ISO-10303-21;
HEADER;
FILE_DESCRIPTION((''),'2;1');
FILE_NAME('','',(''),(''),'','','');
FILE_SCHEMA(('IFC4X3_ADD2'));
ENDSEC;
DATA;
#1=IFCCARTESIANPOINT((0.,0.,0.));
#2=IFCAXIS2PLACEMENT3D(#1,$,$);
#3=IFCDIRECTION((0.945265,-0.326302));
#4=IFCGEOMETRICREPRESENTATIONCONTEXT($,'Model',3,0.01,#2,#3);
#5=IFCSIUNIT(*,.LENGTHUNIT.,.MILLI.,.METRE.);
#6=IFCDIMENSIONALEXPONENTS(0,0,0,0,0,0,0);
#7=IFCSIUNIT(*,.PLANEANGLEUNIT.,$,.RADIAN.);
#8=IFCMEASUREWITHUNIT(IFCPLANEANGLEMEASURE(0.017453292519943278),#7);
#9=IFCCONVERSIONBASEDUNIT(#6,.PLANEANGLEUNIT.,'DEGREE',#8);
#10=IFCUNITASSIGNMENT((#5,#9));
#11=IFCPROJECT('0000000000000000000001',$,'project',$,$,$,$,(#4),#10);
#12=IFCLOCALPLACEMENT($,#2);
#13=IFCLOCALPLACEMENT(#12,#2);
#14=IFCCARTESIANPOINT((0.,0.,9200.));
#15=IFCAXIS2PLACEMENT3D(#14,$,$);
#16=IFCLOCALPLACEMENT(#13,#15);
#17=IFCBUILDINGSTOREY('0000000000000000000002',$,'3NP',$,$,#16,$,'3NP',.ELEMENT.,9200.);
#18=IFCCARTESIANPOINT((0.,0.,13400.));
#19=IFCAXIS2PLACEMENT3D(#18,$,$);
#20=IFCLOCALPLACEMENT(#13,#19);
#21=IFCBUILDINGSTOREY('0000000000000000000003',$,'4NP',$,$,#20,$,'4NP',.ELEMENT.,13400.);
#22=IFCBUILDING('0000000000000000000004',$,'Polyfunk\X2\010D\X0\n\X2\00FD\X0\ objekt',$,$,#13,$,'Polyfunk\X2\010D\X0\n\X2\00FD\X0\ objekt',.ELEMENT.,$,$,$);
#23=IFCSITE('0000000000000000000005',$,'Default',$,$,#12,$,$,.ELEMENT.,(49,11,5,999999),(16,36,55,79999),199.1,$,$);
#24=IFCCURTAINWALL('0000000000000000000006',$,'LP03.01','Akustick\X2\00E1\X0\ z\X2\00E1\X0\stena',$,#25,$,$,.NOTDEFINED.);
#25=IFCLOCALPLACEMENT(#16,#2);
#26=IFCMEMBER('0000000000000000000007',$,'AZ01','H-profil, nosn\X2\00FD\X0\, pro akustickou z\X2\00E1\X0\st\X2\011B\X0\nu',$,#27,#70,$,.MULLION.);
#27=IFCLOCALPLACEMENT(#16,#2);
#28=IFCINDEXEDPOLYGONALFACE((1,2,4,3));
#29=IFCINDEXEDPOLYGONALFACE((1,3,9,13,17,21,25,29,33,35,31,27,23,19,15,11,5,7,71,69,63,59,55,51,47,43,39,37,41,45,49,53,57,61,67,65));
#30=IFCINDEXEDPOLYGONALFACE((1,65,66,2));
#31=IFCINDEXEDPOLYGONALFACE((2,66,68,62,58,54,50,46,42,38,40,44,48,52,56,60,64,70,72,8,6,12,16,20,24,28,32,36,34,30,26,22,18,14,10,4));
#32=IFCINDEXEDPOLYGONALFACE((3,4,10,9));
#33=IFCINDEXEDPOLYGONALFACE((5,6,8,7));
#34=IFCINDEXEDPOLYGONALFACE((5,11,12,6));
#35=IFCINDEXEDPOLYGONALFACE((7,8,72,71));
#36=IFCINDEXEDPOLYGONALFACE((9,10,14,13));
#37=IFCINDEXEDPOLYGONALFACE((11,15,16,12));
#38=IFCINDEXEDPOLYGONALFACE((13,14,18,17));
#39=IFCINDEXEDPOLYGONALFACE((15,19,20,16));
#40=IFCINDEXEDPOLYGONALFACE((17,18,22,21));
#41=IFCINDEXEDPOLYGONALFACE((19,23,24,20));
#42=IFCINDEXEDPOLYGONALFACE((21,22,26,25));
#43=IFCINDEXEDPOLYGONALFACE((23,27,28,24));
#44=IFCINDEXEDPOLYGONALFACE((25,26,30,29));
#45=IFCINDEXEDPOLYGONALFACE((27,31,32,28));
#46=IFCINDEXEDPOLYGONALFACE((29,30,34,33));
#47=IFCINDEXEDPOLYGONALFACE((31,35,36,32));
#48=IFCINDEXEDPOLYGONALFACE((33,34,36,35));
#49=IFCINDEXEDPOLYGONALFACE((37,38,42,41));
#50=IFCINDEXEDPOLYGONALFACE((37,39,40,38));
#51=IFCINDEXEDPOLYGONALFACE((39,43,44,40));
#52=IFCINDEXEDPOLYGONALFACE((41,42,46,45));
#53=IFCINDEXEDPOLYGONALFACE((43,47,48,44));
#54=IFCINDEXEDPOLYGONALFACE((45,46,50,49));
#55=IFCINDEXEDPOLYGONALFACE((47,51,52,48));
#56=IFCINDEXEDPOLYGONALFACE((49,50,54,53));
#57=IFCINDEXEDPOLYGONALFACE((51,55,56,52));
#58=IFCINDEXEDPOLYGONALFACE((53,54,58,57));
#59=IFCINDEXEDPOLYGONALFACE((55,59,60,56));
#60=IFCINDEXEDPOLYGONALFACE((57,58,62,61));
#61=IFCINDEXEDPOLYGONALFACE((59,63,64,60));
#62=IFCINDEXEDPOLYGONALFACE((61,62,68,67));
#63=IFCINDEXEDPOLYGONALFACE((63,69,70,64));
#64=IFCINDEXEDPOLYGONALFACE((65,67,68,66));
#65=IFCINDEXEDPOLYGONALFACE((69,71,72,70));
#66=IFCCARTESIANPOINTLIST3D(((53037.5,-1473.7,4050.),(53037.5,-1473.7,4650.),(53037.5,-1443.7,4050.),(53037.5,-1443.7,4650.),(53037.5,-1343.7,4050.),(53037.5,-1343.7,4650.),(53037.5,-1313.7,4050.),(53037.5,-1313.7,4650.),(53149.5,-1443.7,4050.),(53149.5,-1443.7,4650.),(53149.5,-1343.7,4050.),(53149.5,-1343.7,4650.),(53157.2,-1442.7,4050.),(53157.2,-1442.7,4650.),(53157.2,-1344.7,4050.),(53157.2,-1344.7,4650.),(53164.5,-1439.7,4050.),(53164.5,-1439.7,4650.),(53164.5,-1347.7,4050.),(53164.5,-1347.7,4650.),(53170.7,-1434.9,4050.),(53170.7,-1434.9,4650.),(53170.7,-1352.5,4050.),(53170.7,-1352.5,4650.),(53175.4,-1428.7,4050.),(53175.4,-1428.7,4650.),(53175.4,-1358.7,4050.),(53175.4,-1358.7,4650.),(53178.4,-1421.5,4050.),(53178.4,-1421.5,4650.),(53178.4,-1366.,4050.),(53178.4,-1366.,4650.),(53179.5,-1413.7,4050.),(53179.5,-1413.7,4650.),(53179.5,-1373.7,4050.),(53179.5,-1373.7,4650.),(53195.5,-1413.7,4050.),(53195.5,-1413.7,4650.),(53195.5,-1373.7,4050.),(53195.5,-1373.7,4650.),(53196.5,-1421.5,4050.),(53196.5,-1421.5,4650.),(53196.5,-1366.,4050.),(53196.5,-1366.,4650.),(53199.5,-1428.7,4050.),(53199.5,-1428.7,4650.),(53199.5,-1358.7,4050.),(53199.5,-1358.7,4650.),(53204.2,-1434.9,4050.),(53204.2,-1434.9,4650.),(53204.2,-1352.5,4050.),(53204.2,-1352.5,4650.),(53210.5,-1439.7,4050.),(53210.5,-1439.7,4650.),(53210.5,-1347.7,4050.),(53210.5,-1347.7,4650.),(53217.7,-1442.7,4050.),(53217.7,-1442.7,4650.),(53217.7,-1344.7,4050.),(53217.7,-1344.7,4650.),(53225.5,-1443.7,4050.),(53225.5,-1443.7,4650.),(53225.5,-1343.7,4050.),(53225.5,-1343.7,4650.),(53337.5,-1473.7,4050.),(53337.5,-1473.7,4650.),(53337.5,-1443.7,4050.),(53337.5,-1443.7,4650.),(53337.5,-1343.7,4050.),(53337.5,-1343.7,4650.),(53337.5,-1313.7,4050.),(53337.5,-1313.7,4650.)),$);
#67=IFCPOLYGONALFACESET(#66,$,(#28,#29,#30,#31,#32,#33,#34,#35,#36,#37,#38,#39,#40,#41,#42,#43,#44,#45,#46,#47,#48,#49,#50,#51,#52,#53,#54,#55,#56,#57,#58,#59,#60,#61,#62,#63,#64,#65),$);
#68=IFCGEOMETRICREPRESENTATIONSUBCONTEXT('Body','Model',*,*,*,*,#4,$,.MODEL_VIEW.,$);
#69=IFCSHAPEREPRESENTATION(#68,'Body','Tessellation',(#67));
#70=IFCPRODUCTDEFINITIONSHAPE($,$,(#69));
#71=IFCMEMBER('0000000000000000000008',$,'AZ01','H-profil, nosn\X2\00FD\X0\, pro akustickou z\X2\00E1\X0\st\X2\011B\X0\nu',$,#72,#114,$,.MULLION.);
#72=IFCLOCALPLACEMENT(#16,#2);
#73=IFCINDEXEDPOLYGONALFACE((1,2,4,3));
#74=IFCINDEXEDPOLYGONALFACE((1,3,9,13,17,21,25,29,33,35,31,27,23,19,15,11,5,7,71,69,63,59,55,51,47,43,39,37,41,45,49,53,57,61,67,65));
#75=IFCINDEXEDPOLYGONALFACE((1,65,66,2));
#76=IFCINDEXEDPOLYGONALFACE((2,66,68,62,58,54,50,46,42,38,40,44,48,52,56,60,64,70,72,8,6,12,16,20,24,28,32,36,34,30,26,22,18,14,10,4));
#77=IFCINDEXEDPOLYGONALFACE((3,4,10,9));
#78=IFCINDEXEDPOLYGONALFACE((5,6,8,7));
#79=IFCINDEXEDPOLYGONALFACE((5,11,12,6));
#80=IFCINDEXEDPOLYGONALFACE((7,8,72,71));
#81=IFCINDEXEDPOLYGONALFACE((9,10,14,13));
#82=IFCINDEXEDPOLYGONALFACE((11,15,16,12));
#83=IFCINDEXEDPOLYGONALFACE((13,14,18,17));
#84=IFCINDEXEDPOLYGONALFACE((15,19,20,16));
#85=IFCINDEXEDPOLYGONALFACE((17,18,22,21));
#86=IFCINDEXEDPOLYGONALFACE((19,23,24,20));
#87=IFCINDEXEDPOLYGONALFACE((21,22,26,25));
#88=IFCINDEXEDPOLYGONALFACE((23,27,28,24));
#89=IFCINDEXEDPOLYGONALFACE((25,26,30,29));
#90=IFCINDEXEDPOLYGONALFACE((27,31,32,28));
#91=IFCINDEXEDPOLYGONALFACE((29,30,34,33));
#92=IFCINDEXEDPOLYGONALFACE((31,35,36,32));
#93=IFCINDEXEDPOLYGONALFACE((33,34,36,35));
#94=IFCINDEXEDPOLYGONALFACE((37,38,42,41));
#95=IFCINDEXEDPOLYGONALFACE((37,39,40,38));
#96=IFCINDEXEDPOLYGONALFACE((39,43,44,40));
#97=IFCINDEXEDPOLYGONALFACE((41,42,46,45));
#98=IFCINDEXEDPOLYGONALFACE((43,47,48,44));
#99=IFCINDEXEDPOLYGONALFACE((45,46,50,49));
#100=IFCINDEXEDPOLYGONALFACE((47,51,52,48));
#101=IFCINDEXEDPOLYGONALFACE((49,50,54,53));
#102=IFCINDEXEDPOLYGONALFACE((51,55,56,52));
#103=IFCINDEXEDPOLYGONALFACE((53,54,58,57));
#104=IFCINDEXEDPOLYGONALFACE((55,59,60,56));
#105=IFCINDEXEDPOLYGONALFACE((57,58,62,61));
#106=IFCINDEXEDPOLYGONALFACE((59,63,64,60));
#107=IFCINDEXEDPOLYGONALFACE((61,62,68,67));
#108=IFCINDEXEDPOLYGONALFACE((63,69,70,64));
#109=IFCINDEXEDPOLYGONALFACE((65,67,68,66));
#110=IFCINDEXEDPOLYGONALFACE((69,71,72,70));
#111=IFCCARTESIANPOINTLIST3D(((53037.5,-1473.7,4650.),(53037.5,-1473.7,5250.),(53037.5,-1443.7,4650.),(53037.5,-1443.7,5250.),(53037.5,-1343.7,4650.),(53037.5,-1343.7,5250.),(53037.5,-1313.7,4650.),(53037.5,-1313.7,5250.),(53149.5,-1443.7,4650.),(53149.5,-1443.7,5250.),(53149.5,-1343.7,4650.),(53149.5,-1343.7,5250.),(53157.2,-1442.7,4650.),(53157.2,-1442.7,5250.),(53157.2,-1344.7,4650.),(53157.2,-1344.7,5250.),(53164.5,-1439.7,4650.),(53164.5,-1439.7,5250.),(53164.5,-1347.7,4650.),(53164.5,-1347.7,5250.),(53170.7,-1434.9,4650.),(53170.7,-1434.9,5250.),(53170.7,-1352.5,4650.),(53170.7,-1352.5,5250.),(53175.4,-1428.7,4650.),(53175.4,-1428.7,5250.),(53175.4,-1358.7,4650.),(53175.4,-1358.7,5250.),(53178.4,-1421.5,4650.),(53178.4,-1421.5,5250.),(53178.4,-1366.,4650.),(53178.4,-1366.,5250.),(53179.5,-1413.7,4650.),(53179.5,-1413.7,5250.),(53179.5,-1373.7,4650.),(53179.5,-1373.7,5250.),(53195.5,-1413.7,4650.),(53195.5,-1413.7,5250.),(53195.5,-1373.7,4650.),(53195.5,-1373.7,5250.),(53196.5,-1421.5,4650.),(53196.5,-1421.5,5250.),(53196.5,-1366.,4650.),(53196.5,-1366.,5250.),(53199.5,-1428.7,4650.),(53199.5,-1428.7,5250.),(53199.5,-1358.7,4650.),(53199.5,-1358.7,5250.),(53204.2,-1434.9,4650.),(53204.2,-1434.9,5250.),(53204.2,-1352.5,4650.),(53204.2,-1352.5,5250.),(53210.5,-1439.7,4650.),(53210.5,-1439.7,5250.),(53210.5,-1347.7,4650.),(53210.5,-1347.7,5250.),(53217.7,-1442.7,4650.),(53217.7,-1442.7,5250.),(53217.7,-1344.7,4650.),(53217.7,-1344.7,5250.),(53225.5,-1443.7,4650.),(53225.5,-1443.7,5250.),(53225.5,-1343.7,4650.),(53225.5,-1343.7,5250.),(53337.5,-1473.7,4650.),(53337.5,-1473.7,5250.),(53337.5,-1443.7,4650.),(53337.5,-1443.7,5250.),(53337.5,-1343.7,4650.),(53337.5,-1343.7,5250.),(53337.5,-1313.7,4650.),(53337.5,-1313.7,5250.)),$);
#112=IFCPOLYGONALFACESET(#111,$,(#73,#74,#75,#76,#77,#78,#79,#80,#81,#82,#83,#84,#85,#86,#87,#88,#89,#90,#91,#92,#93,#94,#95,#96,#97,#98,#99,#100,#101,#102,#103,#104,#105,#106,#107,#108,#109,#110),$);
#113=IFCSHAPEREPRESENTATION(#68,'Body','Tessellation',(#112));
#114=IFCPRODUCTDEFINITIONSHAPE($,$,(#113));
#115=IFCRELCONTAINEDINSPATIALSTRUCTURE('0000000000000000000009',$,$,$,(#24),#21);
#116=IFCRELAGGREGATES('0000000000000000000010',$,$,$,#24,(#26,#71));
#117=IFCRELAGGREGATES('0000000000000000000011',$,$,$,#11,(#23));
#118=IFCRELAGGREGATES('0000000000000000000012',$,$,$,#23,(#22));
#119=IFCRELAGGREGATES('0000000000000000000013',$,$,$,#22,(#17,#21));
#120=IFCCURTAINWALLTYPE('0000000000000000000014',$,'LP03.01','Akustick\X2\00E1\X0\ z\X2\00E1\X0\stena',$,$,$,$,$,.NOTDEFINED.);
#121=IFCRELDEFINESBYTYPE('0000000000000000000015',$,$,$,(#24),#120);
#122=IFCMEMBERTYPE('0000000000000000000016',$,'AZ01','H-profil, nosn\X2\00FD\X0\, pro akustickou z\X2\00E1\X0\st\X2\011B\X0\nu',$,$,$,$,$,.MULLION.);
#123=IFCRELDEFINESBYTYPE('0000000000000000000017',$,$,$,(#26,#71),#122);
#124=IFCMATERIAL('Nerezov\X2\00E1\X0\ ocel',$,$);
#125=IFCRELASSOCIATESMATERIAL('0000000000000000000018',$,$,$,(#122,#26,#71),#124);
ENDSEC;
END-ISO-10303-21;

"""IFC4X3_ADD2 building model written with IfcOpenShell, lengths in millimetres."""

from ifc_helpers import new_model, entity, si_unit, converted_unit, direction, frame, frame_2d, origin, place, context, subcontext, project, spatial, polyline, circle_curve, parameter, trimmed, segment, composite_curve, outline, extrude, source, transform, mapped, material, material_profile, profile_set, profile_usage, type_object, element, aggregate, save


model = new_model("IFC4X3_ADD2")

# Units and contexts
model_context = context("Model", 3, precision=0.01, world=origin(), true_north=direction((0.945265, -0.326302)))
body_context = subcontext(model_context, "Body", "Model", "MODEL_VIEW")
ifc_project = project(units=[si_unit("LENGTHUNIT", "METRE", prefix="MILLI"), converted_unit("PLANEANGLEUNIT", "DEGREE", entity("IfcPlaneAngleMeasure", 0.017453292519943278), si_unit("PLANEANGLEUNIT", "RADIAN"), dimensions=[0, 0, 0, 0, 0, 0, 0])], contexts=[model_context])

# Site, building, storey
site_placement = place(None, origin())
site = spatial("IfcSite", under=ifc_project, at=site_placement, Name="Default", CompositionType="ELEMENT", RefLatitude=(49, 11, 5, 999999), RefLongitude=(16, 36, 55, 79999), RefElevation=199.1)
building_placement = place(site_placement, origin())
building = spatial("IfcBuilding", under=site, at=building_placement, Name="Polyfunkčný objekt", LongName="Polyfunkčný objekt", CompositionType="ELEMENT")
storey_1_placement = place(building_placement, frame((0.0, 0.0, 9200.0)))
storey_1 = spatial("IfcBuildingStorey", under=building, at=storey_1_placement, Name="3NP", LongName="3NP", CompositionType="ELEMENT", Elevation=9200.0)

# Shared definitions
storey_2_placement = place(building_placement, frame((0.0, 0.0, 13400.0)))
storey_2 = spatial("IfcBuildingStorey", under=building, at=storey_2_placement, Name="4NP", LongName="4NP", CompositionType="ELEMENT", Elevation=13400.0)

# Curtain wall, members
curtain_wall_type_1 = type_object("IfcCurtainWallType", Name="LP03.01", Description="Akustická zástena", PredefinedType="NOTDEFINED")
curtain_wall_1_placement = place(storey_2_placement, frame((0.0, 0.0, -13400.0)))
curtain_wall_1 = element("IfcCurtainWall", 1, at=curtain_wall_1_placement, inside=storey_2, type_object=curtain_wall_type_1, Name="LP03.01", Description="Akustická zástena", PredefinedType="NOTDEFINED")
ifc_material_1 = material(Name="Nerezová ocel")
ifc_material_profile_1 = material_profile(ifc_material_1, outline(composite_curve([segment(polyline([(50.0, -150.0), (80.0, -150.0)]), True, "CONTINUOUS"), segment(polyline([(80.0, -150.0), (80.0, 150.0)]), True, "CONTINUOUS"), segment(polyline([(80.0, 150.0), (50.0, 150.0)]), True, "CONTINUOUS"), segment(polyline([(50.0, 150.0), (50.0, 38.0)]), True, "CONTINUOUS"), segment(trimmed(circle_curve(frame_2d((20.0, 38.0), x_axis=(0.0, 1.0)), 30.0), [parameter(180.0)], [parameter(270.0)], True, "PARAMETER"), False, "CONTINUOUS"), segment(polyline([(20.0, 8.0), (-20.0, 8.0)]), True, "CONTINUOUS"), segment(trimmed(circle_curve(frame_2d((-20.0, 38.0), x_axis=(0.0, 1.0)), 30.0), [parameter(90.0)], [parameter(180.0)], True, "PARAMETER"), False, "CONTINUOUS"), segment(polyline([(-50.0, 38.0), (-50.0, 150.0)]), True, "CONTINUOUS"), segment(polyline([(-50.0, 150.0), (-80.0, 150.0)]), True, "CONTINUOUS"), segment(polyline([(-80.0, 150.0), (-80.0, -150.0)]), True, "CONTINUOUS"), segment(polyline([(-80.0, -150.0), (-50.0, -150.0)]), True, "CONTINUOUS"), segment(polyline([(-50.0, -150.0), (-50.0, -38.0)]), True, "CONTINUOUS"), segment(trimmed(circle_curve(frame_2d((-20.0, -38.0), x_axis=(0.0, 1.0)), 30.0), [parameter(0.0)], [parameter(90.0)], True, "PARAMETER"), False, "CONTINUOUS"), segment(polyline([(-20.0, -8.0), (20.0, -8.0)]), True, "CONTINUOUS"), segment(trimmed(circle_curve(frame_2d((20.0, -38.0), x_axis=(0.0, 1.0)), 30.0), [parameter(270.0)], [parameter(0.0)], True, "PARAMETER"), False, "CONTINUOUS"), segment(polyline([(50.0, -38.0), (50.0, -150.0)]), True, "CONTINUOUS")], self_intersect=False)), Name="Profil zástena")
ifc_profile_set_1 = profile_set([ifc_material_profile_1], Name="Profil zástena")
ifc_profile_usage_1 = profile_usage(ifc_profile_set_1)
member_type_1 = type_object("IfcMemberType", Name="AZ01", Description="H-profil, nosný, pro akustickou zástěnu", PredefinedType="MULLION", material=ifc_profile_set_1)
shared_shape_1 = source(origin(), body_context, "Body", "SweptSolid", [
    extrude(outline(composite_curve([segment(polyline([(50.0, -150.0), (80.0, -150.0)]), True, "CONTINUOUS"), segment(polyline([(80.0, -150.0), (80.0, 150.0)]), True, "CONTINUOUS"), segment(polyline([(80.0, 150.0), (50.0, 150.0)]), True, "CONTINUOUS"), segment(polyline([(50.0, 150.0), (50.0, 38.0)]), True, "CONTINUOUS"), segment(trimmed(circle_curve(frame_2d((20.0, 38.0), x_axis=(0.0, 1.0)), 30.0), [parameter(180.0)], [parameter(270.0)], True, "PARAMETER"), False, "CONTINUOUS"), segment(polyline([(20.0, 8.0), (-20.0, 8.0)]), True, "CONTINUOUS"), segment(trimmed(circle_curve(frame_2d((-20.0, 38.0), x_axis=(0.0, 1.0)), 30.0), [parameter(90.0)], [parameter(180.0)], True, "PARAMETER"), False, "CONTINUOUS"), segment(polyline([(-50.0, 38.0), (-50.0, 150.0)]), True, "CONTINUOUS"), segment(polyline([(-50.0, 150.0), (-80.0, 150.0)]), True, "CONTINUOUS"), segment(polyline([(-80.0, 150.0), (-80.0, -150.0)]), True, "CONTINUOUS"), segment(polyline([(-80.0, -150.0), (-50.0, -150.0)]), True, "CONTINUOUS"), segment(polyline([(-50.0, -150.0), (-50.0, -38.0)]), True, "CONTINUOUS"), segment(trimmed(circle_curve(frame_2d((-20.0, -38.0), x_axis=(0.0, 1.0)), 30.0), [parameter(0.0)], [parameter(90.0)], True, "PARAMETER"), False, "CONTINUOUS"), segment(polyline([(-20.0, -8.0), (20.0, -8.0)]), True, "CONTINUOUS"), segment(trimmed(circle_curve(frame_2d((20.0, -38.0), x_axis=(0.0, 1.0)), 30.0), [parameter(270.0)], [parameter(0.0)], True, "PARAMETER"), False, "CONTINUOUS"), segment(polyline([(50.0, -38.0), (50.0, -150.0)]), True, "CONTINUOUS")], self_intersect=False)), frame((0.0, 0.0, -600.0), z_axis=(0.0, 0.0, 1.0), x_axis=(0.0, -1.0, 0.0)), (0.0, 0.0, 1.0), 600.0),
])
member_1_placement = place(curtain_wall_1_placement, frame((53187.5, -1393.7, 13250.0), z_axis=(0.0, 0.0, -1.0), x_axis=(1.0, 0.0, 0.0)))
member_1 = element("IfcMember", 2, at=member_1_placement, type_object=member_type_1, material=ifc_profile_usage_1, Name="AZ01", Description="H-profil, nosný, pro akustickou zástěnu", PredefinedType="MULLION", context=body_context, shape_type="MappedRepresentation", body=[
    mapped(shared_shape_1, transform((0.0, 0.0, 0.0), scale=1.0)),
])
shared_shape_2 = source(origin(), body_context, "Body", "SweptSolid", [
    extrude(outline(composite_curve([segment(polyline([(50.0, -150.0), (80.0, -150.0)]), True, "CONTINUOUS"), segment(polyline([(80.0, -150.0), (80.0, 150.0)]), True, "CONTINUOUS"), segment(polyline([(80.0, 150.0), (50.0, 150.0)]), True, "CONTINUOUS"), segment(polyline([(50.0, 150.0), (50.0, 38.0)]), True, "CONTINUOUS"), segment(trimmed(circle_curve(frame_2d((20.0, 38.0), x_axis=(0.0, 1.0)), 30.0), [parameter(180.0)], [parameter(270.0)], True, "PARAMETER"), False, "CONTINUOUS"), segment(polyline([(20.0, 8.0), (-20.0, 8.0)]), True, "CONTINUOUS"), segment(trimmed(circle_curve(frame_2d((-20.0, 38.0), x_axis=(0.0, 1.0)), 30.0), [parameter(90.0)], [parameter(180.0)], True, "PARAMETER"), False, "CONTINUOUS"), segment(polyline([(-50.0, 38.0), (-50.0, 150.0)]), True, "CONTINUOUS"), segment(polyline([(-50.0, 150.0), (-80.0, 150.0)]), True, "CONTINUOUS"), segment(polyline([(-80.0, 150.0), (-80.0, -150.0)]), True, "CONTINUOUS"), segment(polyline([(-80.0, -150.0), (-50.0, -150.0)]), True, "CONTINUOUS"), segment(polyline([(-50.0, -150.0), (-50.0, -38.0)]), True, "CONTINUOUS"), segment(trimmed(circle_curve(frame_2d((-20.0, -38.0), x_axis=(0.0, 1.0)), 30.0), [parameter(0.0)], [parameter(90.0)], True, "PARAMETER"), False, "CONTINUOUS"), segment(polyline([(-20.0, -8.0), (20.0, -8.0)]), True, "CONTINUOUS"), segment(trimmed(circle_curve(frame_2d((20.0, -38.0), x_axis=(0.0, 1.0)), 30.0), [parameter(270.0)], [parameter(0.0)], True, "PARAMETER"), False, "CONTINUOUS"), segment(polyline([(50.0, -38.0), (50.0, -150.0)]), True, "CONTINUOUS")], self_intersect=False)), frame((0.0, 0.0, -600.0), z_axis=(0.0, 0.0, 1.0), x_axis=(0.0, -1.0, 0.0)), (0.0, 0.0, 1.0), 600.0),
])
member_2_placement = place(curtain_wall_1_placement, frame((53187.5, -1393.7, 13850.0), z_axis=(0.0, 0.0, -1.0), x_axis=(1.0, 0.0, 0.0)))
member_2 = element("IfcMember", 3, at=member_2_placement, type_object=member_type_1, material=ifc_profile_usage_1, Name="AZ01", Description="H-profil, nosný, pro akustickou zástěnu", PredefinedType="MULLION", context=body_context, shape_type="MappedRepresentation", body=[
    mapped(shared_shape_2, transform((0.0, 0.0, 0.0), scale=1.0)),
])
aggregate(curtain_wall_1, [member_1, member_2])

save(model, "model.ifc")
